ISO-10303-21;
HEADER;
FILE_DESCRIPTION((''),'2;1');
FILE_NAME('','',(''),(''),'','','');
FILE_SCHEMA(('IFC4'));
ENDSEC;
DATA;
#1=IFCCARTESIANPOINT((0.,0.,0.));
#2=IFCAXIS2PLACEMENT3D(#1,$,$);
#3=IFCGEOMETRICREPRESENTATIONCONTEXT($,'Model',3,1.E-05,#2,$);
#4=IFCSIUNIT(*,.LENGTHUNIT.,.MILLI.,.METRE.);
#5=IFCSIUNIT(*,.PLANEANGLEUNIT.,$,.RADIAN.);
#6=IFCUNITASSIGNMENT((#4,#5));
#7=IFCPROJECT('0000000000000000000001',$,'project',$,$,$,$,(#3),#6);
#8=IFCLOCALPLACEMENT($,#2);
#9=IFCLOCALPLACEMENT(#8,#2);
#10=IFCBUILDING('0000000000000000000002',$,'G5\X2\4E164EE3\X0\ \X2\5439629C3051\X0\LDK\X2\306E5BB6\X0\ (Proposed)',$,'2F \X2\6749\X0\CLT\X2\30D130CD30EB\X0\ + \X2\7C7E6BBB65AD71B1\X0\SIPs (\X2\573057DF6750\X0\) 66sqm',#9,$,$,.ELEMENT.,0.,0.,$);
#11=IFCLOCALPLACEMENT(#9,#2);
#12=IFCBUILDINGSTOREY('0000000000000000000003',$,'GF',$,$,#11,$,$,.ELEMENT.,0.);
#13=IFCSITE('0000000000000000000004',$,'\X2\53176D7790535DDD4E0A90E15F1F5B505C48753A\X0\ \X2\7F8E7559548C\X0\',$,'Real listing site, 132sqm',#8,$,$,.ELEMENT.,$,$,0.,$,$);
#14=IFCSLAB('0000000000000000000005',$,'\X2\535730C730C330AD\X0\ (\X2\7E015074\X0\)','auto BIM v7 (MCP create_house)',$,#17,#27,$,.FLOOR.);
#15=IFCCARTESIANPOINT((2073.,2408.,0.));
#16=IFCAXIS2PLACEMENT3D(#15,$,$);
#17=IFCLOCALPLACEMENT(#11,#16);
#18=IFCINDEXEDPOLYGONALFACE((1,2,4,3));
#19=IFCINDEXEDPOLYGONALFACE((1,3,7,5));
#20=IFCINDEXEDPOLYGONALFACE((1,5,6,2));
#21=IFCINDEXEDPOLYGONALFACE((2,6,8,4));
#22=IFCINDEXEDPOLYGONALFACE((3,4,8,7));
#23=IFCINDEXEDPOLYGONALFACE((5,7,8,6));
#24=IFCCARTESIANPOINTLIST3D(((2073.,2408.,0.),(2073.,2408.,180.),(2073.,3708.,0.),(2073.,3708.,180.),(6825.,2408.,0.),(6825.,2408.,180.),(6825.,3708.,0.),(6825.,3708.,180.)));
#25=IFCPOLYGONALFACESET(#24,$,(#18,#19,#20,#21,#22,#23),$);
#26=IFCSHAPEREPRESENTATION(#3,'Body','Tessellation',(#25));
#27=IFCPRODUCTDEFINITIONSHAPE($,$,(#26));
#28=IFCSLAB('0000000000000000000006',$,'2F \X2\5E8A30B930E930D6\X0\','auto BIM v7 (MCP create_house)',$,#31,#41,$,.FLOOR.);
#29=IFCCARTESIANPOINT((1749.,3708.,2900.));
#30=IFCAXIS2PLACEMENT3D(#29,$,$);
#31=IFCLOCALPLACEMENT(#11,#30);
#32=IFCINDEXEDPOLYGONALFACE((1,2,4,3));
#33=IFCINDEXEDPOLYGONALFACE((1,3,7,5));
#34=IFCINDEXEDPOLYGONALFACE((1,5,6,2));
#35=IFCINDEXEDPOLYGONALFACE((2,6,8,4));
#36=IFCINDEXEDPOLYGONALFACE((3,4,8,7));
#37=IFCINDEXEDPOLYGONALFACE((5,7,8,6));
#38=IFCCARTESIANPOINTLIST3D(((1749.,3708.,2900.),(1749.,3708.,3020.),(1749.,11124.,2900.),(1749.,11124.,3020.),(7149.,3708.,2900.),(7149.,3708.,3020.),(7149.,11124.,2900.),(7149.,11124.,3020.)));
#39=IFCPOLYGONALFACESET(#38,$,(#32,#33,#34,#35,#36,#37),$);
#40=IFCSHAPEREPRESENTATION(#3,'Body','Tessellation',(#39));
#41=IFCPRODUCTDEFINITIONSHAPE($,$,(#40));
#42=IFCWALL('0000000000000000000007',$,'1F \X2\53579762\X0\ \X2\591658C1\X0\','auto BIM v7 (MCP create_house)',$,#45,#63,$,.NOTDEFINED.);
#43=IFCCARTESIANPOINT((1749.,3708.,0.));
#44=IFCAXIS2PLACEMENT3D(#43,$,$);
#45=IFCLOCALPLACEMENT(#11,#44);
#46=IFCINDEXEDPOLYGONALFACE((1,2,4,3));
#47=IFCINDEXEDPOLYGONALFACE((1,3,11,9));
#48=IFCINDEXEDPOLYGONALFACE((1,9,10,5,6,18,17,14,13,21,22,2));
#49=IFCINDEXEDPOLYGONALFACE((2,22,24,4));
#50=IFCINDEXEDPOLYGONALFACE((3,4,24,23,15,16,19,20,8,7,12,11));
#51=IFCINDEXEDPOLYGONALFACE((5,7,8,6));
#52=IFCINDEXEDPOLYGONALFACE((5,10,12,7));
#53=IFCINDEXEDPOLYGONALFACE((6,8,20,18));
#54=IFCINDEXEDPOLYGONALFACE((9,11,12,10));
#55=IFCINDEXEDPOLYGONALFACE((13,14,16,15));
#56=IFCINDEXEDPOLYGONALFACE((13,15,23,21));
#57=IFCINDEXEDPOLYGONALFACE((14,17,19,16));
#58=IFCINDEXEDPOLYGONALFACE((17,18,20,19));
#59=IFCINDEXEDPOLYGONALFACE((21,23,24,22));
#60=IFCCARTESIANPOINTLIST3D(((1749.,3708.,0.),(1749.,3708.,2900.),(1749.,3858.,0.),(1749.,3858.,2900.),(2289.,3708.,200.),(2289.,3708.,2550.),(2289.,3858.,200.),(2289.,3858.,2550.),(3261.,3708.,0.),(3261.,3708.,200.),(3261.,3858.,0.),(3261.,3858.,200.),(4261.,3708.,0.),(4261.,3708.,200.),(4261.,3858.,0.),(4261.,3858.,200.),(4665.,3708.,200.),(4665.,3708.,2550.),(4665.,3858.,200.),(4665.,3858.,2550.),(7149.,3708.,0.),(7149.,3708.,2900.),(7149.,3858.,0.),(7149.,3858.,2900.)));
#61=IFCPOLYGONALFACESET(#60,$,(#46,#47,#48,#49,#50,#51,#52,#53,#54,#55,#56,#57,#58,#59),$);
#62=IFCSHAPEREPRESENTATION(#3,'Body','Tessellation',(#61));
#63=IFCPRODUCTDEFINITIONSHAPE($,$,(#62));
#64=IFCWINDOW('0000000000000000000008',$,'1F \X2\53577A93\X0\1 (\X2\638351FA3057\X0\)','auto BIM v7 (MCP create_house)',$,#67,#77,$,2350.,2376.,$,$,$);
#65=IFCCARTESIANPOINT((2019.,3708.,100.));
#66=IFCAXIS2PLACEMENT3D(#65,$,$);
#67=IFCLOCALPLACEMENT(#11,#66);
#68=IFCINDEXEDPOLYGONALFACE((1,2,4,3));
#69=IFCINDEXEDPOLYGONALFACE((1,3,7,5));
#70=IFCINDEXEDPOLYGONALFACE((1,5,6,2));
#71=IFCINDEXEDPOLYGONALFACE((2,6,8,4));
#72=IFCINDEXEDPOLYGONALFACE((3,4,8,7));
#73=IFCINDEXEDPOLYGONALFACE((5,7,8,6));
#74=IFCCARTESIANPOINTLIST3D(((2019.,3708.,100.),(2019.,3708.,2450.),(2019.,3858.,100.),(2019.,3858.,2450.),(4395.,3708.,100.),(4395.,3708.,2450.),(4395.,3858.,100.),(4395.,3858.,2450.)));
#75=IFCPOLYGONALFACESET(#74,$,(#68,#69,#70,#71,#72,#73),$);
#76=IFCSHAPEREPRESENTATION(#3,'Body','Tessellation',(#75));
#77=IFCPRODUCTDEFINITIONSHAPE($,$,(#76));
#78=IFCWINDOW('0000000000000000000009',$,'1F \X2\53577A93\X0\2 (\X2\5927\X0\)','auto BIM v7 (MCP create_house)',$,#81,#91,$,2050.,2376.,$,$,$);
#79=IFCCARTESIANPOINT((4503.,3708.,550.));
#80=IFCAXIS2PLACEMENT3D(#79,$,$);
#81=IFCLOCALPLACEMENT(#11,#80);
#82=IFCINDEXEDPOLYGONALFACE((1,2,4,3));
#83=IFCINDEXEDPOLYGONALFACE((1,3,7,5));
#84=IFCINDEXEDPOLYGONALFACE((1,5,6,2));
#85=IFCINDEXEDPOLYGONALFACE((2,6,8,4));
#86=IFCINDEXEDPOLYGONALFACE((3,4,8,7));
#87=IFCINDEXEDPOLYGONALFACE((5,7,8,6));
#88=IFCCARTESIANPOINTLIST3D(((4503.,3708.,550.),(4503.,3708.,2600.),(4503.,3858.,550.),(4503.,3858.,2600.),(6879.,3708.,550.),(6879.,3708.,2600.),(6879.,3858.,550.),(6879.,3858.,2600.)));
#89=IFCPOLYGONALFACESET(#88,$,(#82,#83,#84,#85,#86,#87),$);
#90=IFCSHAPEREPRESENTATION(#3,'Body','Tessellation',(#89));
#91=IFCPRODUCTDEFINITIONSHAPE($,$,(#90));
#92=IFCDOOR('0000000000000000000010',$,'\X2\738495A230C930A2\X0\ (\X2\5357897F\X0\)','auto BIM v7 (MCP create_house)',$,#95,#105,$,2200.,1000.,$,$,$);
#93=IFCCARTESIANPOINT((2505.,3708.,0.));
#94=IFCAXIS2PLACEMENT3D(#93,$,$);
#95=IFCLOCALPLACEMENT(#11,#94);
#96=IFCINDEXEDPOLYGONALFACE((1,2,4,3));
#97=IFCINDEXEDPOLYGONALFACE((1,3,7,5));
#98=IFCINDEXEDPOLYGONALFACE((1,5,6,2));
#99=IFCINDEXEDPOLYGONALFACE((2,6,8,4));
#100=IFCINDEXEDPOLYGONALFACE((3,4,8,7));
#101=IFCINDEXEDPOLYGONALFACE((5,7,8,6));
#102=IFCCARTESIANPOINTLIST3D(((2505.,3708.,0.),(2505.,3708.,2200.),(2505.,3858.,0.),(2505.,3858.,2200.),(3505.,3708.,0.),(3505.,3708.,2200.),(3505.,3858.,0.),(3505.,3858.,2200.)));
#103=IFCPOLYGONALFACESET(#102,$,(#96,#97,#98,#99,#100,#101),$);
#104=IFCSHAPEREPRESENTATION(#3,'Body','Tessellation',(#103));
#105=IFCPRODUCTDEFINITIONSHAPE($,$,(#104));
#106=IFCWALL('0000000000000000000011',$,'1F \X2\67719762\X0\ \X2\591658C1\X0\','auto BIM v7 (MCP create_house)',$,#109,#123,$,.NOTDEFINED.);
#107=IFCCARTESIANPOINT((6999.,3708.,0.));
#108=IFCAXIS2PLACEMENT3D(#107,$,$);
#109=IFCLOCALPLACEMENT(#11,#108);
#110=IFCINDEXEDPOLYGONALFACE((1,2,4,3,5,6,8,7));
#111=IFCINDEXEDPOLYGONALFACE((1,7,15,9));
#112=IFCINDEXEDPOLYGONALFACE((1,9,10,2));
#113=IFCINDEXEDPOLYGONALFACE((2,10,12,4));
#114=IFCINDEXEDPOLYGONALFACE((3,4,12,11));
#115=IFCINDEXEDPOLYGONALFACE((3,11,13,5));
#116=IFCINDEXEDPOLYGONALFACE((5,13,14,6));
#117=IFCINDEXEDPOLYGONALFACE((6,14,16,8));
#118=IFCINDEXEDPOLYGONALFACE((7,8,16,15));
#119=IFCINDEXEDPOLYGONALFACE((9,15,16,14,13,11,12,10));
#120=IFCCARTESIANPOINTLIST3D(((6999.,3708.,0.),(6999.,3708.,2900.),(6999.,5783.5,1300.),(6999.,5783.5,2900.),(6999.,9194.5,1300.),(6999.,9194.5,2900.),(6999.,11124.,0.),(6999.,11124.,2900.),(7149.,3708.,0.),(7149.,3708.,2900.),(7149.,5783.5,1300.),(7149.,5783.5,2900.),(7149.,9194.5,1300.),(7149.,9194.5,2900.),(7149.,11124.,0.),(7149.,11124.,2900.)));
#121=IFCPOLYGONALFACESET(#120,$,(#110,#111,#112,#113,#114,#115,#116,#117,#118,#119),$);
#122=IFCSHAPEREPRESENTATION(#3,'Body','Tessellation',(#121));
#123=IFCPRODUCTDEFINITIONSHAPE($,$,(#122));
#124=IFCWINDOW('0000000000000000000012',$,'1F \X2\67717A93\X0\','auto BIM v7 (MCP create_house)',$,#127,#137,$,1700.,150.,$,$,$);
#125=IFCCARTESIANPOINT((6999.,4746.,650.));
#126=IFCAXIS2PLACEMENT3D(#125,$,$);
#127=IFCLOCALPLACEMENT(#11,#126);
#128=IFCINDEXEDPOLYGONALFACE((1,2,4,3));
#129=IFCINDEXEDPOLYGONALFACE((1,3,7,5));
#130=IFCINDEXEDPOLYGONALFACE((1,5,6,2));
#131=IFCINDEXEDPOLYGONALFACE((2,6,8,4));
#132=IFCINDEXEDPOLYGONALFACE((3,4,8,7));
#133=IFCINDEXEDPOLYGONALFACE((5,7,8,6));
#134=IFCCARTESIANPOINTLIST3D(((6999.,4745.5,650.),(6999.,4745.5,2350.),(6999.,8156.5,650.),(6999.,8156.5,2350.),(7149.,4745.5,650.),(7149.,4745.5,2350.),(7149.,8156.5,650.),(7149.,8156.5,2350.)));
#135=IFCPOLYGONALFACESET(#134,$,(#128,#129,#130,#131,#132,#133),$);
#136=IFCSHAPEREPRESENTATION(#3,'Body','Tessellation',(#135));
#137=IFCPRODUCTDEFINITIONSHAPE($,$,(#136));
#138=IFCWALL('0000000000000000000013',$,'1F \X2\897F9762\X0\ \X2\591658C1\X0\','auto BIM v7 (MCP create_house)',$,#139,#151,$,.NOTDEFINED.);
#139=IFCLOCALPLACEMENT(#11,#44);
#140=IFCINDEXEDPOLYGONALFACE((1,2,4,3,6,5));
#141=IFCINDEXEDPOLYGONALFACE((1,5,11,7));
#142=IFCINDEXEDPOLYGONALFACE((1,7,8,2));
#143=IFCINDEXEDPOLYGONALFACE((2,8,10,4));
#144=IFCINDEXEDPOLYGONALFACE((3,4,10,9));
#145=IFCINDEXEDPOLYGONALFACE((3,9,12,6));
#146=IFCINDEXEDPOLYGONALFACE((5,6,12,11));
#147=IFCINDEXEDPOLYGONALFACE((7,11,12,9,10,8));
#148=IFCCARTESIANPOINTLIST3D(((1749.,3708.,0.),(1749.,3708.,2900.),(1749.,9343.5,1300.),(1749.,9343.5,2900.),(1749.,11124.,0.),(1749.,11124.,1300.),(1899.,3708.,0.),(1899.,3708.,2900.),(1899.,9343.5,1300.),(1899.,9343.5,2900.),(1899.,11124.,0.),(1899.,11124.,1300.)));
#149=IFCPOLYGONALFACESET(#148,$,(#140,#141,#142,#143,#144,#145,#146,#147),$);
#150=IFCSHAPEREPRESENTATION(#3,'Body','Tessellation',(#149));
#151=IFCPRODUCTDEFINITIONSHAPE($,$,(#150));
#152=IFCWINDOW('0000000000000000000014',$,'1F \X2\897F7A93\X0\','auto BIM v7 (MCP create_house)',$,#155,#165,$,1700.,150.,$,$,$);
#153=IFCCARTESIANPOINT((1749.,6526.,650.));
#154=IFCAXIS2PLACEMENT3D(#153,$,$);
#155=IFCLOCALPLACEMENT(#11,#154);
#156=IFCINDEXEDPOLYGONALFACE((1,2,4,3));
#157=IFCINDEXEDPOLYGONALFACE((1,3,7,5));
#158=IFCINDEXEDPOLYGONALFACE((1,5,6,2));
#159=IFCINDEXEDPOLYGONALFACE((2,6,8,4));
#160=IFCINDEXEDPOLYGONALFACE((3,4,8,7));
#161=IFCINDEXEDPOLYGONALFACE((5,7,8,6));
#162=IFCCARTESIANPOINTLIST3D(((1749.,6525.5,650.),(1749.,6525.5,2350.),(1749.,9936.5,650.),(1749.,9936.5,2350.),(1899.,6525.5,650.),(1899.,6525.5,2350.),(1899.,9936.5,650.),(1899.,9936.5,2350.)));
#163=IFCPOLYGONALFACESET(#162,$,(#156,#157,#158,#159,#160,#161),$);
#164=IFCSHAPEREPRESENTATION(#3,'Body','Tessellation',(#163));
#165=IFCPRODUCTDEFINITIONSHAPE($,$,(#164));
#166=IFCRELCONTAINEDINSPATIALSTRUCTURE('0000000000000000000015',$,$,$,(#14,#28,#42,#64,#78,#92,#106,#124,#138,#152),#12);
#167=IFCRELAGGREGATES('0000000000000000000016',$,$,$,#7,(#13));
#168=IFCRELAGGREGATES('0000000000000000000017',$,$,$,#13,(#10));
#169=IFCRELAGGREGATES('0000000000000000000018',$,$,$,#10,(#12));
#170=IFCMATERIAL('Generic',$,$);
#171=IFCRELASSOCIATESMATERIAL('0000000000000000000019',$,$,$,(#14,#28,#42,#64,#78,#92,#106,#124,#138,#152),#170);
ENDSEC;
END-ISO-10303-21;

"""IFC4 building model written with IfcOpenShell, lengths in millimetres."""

from ifc_helpers import new_model, si_unit, frame, frame_2d, origin, place, context, project, spatial, rectangle, extrude, material, element, fill, save


model = new_model("IFC4")

# Units and contexts
model_context = context("Model", 3, precision=1e-05, world=origin())
ifc_project = project(units=[si_unit("LENGTHUNIT", "METRE", prefix="MILLI"), si_unit("PLANEANGLEUNIT", "RADIAN")], contexts=[model_context])

# Site, building, storey
site_placement = place(None, origin())
site = spatial("IfcSite", under=ifc_project, at=site_placement, Name="北海道川上郡弟子屈町 美留和", ObjectType="Real listing site, 132sqm", CompositionType="ELEMENT", RefElevation=0.0)
building_placement = place(site_placement, origin())
building = spatial("IfcBuilding", under=site, at=building_placement, Name="G5世代 吹抜けLDKの家 (Proposed)", ObjectType="2F 杉CLTパネル + 籾殻断熱SIPs (地域材) 66sqm", CompositionType="ELEMENT", ElevationOfRefHeight=0.0, ElevationOfTerrain=0.0)
storey_placement = place(building_placement, origin())
storey = spatial("IfcBuildingStorey", under=building, at=storey_placement, Name="GF", CompositionType="ELEMENT", Elevation=0.0)

# Slabs
ifc_material = material(Name="Generic")
slab_1_placement = place(storey_placement, frame((2073.0, 2408.0, 0.0)))
element("IfcSlab", 1, at=slab_1_placement, inside=storey, material=ifc_material, Name="南デッキ (縁側)", Description="auto BIM v7 (MCP create_house)", PredefinedType="FLOOR", context=model_context, shape_type="SweptSolid", body=[
    extrude(rectangle(XDim=4752.0, YDim=1300.0, at=frame_2d((2376.0, 650.0))), frame((2073.0, 2408.0, 0.0)), (0.0, 0.0, 1.0), 180.0),
])
slab_2_placement = place(storey_placement, frame((1749.0, 3708.0, 2900.0)))
element("IfcSlab", 2, at=slab_2_placement, inside=storey, material=ifc_material, Name="2F 床スラブ", Description="auto BIM v7 (MCP create_house)", PredefinedType="FLOOR", context=model_context, shape_type="SweptSolid", body=[
    extrude(rectangle(XDim=5400.0, YDim=7416.0, at=frame_2d((2700.0, 3708.0))), frame((1749.0, 3708.0, 2900.0)), (0.0, 0.0, 1.0), 120.0),
])

# Wall, openings, windows, door
wall_1_placement = place(storey_placement, frame((1749.0, 3708.0, 0.0)))
wall_1 = element("IfcWall", 3, at=wall_1_placement, inside=storey, material=ifc_material, Name="1F 南面 外壁", Description="auto BIM v7 (MCP create_house)", PredefinedType="NOTDEFINED", context=model_context, shape_type="SweptSolid", body=[
    extrude(rectangle(XDim=5400.0, YDim=150.0, at=frame_2d((2700.0, 75.0))), frame((1749.0, 3708.0, 0.0)), (0.0, 0.0, 1.0), 2900.0),
])
opening_1_placement = place(storey_placement, frame((2019.0, 3708.0, 100.0)))
opening_1 = element("IfcOpeningElement", 4, at=opening_1_placement, cuts=wall_1, PredefinedType="NOTDEFINED", context=model_context, shape_type="SweptSolid", body=[
    extrude(rectangle(XDim=2376.0, YDim=150.0, at=frame_2d((1188.0, 75.0))), frame((2019.0, 3708.0, 100.0)), (0.0, 0.0, 1.0), 2350.0),
])
opening_2_placement = place(storey_placement, frame((4503.0, 3708.0, 550.0)))
opening_2 = element("IfcOpeningElement", 5, at=opening_2_placement, cuts=wall_1, PredefinedType="NOTDEFINED", context=model_context, shape_type="SweptSolid", body=[
    extrude(rectangle(XDim=2376.0, YDim=150.0, at=frame_2d((1188.0, 75.0))), frame((4503.0, 3708.0, 550.0)), (0.0, 0.0, 1.0), 2050.0),
])
opening_3_placement = place(storey_placement, frame((2505.0, 3708.0, 0.0)))
opening_3 = element("IfcOpeningElement", 6, at=opening_3_placement, cuts=wall_1, PredefinedType="NOTDEFINED", context=model_context, shape_type="SweptSolid", body=[
    extrude(rectangle(XDim=1000.0, YDim=150.0, at=frame_2d((500.0, 75.0))), frame((2505.0, 3708.0, 0.0)), (0.0, 0.0, 1.0), 2200.0),
])
window_1_placement = place(storey_placement, frame((2019.0, 3708.0, 100.0)))
window_1 = element("IfcWindow", 7, at=window_1_placement, inside=storey, material=ifc_material, Name="1F 南窓1 (掃出し)", Description="auto BIM v7 (MCP create_house)", OverallHeight=2350.0, OverallWidth=2376.0, context=model_context, shape_type="SweptSolid", body=[
    extrude(rectangle(XDim=2376.0, YDim=150.0, at=frame_2d((1188.0, 75.0))), frame((2019.0, 3708.0, 100.0)), (0.0, 0.0, 1.0), 2350.0),
])
fill(opening_1, window_1)
window_2_placement = place(storey_placement, frame((4503.0, 3708.0, 550.0)))
window_2 = element("IfcWindow", 8, at=window_2_placement, inside=storey, material=ifc_material, Name="1F 南窓2 (大)", Description="auto BIM v7 (MCP create_house)", OverallHeight=2050.0, OverallWidth=2376.0, context=model_context, shape_type="SweptSolid", body=[
    extrude(rectangle(XDim=2376.0, YDim=150.0, at=frame_2d((1188.0, 75.0))), frame((4503.0, 3708.0, 550.0)), (0.0, 0.0, 1.0), 2050.0),
])
fill(opening_2, window_2)
door_placement = place(storey_placement, frame((2505.0, 3708.0, 0.0)))
door = element("IfcDoor", 9, at=door_placement, inside=storey, material=ifc_material, Name="玄関ドア (南西)", Description="auto BIM v7 (MCP create_house)", OverallHeight=2200.0, OverallWidth=1000.0, context=model_context, shape_type="SweptSolid", body=[
    extrude(rectangle(XDim=1000.0, YDim=150.0, at=frame_2d((500.0, 75.0))), frame((2505.0, 3708.0, 0.0)), (0.0, 0.0, 1.0), 2200.0),
])
fill(opening_3, door)

# Walls, openings, windows
wall_2_placement = place(storey_placement, frame((6999.0, 3708.0, 0.0)))
wall_2 = element("IfcWall", 10, at=wall_2_placement, inside=storey, material=ifc_material, Name="1F 東面 外壁", Description="auto BIM v7 (MCP create_house)", PredefinedType="NOTDEFINED", context=model_context, shape_type="SweptSolid", body=[
    extrude(rectangle(XDim=150.0, YDim=7416.0, at=frame_2d((75.0, 3708.0))), frame((6999.0, 3708.0, 0.0)), (0.0, 0.0, 1.0), 2900.0),
])
opening_4_placement = place(storey_placement, frame((6999.0, 4746.0, 650.0)))
opening_4 = element("IfcOpeningElement", 11, at=opening_4_placement, cuts=wall_2, PredefinedType="NOTDEFINED", context=model_context, shape_type="SweptSolid", body=[
    extrude(rectangle(XDim=150.0, YDim=3411.0, at=frame_2d((75.0, 1705.0))), frame((6999.0, 4746.0, 650.0)), (0.0, 0.0, 1.0), 1700.0),
])
window_3_placement = place(storey_placement, frame((6999.0, 4746.0, 650.0)))
window_3 = element("IfcWindow", 12, at=window_3_placement, inside=storey, material=ifc_material, Name="1F 東窓", Description="auto BIM v7 (MCP create_house)", OverallHeight=1700.0, OverallWidth=150.0, context=model_context, shape_type="SweptSolid", body=[
    extrude(rectangle(XDim=150.0, YDim=3411.0, at=frame_2d((75.0, 1705.0))), frame((6999.0, 4746.0, 650.0)), (0.0, 0.0, 1.0), 1700.0),
])
fill(opening_4, window_3)
wall_3_placement = place(storey_placement, frame((1749.0, 3708.0, 0.0)))
wall_3 = element("IfcWall", 13, at=wall_3_placement, inside=storey, material=ifc_material, Name="1F 西面 外壁", Description="auto BIM v7 (MCP create_house)", PredefinedType="NOTDEFINED", context=model_context, shape_type="SweptSolid", body=[
    extrude(rectangle(XDim=150.0, YDim=7416.0, at=frame_2d((75.0, 3708.0))), frame((1749.0, 3708.0, 0.0)), (0.0, 0.0, 1.0), 2900.0),
])
opening_5_placement = place(storey_placement, frame((1749.0, 6526.0, 650.0)))
opening_5 = element("IfcOpeningElement", 14, at=opening_5_placement, cuts=wall_3, PredefinedType="NOTDEFINED", context=model_context, shape_type="SweptSolid", body=[
    extrude(rectangle(XDim=150.0, YDim=3411.0, at=frame_2d((75.0, 1705.0))), frame((1749.0, 6526.0, 650.0)), (0.0, 0.0, 1.0), 1700.0),
])
window_4_placement = place(storey_placement, frame((1749.0, 6526.0, 650.0)))
window_4 = element("IfcWindow", 15, at=window_4_placement, inside=storey, material=ifc_material, Name="1F 西窓", Description="auto BIM v7 (MCP create_house)", OverallHeight=1700.0, OverallWidth=150.0, context=model_context, shape_type="SweptSolid", body=[
    extrude(rectangle(XDim=150.0, YDim=3411.0, at=frame_2d((75.0, 1705.0))), frame((1749.0, 6526.0, 650.0)), (0.0, 0.0, 1.0), 1700.0),
])
fill(opening_5, window_4)

save(model, "model.ifc")
